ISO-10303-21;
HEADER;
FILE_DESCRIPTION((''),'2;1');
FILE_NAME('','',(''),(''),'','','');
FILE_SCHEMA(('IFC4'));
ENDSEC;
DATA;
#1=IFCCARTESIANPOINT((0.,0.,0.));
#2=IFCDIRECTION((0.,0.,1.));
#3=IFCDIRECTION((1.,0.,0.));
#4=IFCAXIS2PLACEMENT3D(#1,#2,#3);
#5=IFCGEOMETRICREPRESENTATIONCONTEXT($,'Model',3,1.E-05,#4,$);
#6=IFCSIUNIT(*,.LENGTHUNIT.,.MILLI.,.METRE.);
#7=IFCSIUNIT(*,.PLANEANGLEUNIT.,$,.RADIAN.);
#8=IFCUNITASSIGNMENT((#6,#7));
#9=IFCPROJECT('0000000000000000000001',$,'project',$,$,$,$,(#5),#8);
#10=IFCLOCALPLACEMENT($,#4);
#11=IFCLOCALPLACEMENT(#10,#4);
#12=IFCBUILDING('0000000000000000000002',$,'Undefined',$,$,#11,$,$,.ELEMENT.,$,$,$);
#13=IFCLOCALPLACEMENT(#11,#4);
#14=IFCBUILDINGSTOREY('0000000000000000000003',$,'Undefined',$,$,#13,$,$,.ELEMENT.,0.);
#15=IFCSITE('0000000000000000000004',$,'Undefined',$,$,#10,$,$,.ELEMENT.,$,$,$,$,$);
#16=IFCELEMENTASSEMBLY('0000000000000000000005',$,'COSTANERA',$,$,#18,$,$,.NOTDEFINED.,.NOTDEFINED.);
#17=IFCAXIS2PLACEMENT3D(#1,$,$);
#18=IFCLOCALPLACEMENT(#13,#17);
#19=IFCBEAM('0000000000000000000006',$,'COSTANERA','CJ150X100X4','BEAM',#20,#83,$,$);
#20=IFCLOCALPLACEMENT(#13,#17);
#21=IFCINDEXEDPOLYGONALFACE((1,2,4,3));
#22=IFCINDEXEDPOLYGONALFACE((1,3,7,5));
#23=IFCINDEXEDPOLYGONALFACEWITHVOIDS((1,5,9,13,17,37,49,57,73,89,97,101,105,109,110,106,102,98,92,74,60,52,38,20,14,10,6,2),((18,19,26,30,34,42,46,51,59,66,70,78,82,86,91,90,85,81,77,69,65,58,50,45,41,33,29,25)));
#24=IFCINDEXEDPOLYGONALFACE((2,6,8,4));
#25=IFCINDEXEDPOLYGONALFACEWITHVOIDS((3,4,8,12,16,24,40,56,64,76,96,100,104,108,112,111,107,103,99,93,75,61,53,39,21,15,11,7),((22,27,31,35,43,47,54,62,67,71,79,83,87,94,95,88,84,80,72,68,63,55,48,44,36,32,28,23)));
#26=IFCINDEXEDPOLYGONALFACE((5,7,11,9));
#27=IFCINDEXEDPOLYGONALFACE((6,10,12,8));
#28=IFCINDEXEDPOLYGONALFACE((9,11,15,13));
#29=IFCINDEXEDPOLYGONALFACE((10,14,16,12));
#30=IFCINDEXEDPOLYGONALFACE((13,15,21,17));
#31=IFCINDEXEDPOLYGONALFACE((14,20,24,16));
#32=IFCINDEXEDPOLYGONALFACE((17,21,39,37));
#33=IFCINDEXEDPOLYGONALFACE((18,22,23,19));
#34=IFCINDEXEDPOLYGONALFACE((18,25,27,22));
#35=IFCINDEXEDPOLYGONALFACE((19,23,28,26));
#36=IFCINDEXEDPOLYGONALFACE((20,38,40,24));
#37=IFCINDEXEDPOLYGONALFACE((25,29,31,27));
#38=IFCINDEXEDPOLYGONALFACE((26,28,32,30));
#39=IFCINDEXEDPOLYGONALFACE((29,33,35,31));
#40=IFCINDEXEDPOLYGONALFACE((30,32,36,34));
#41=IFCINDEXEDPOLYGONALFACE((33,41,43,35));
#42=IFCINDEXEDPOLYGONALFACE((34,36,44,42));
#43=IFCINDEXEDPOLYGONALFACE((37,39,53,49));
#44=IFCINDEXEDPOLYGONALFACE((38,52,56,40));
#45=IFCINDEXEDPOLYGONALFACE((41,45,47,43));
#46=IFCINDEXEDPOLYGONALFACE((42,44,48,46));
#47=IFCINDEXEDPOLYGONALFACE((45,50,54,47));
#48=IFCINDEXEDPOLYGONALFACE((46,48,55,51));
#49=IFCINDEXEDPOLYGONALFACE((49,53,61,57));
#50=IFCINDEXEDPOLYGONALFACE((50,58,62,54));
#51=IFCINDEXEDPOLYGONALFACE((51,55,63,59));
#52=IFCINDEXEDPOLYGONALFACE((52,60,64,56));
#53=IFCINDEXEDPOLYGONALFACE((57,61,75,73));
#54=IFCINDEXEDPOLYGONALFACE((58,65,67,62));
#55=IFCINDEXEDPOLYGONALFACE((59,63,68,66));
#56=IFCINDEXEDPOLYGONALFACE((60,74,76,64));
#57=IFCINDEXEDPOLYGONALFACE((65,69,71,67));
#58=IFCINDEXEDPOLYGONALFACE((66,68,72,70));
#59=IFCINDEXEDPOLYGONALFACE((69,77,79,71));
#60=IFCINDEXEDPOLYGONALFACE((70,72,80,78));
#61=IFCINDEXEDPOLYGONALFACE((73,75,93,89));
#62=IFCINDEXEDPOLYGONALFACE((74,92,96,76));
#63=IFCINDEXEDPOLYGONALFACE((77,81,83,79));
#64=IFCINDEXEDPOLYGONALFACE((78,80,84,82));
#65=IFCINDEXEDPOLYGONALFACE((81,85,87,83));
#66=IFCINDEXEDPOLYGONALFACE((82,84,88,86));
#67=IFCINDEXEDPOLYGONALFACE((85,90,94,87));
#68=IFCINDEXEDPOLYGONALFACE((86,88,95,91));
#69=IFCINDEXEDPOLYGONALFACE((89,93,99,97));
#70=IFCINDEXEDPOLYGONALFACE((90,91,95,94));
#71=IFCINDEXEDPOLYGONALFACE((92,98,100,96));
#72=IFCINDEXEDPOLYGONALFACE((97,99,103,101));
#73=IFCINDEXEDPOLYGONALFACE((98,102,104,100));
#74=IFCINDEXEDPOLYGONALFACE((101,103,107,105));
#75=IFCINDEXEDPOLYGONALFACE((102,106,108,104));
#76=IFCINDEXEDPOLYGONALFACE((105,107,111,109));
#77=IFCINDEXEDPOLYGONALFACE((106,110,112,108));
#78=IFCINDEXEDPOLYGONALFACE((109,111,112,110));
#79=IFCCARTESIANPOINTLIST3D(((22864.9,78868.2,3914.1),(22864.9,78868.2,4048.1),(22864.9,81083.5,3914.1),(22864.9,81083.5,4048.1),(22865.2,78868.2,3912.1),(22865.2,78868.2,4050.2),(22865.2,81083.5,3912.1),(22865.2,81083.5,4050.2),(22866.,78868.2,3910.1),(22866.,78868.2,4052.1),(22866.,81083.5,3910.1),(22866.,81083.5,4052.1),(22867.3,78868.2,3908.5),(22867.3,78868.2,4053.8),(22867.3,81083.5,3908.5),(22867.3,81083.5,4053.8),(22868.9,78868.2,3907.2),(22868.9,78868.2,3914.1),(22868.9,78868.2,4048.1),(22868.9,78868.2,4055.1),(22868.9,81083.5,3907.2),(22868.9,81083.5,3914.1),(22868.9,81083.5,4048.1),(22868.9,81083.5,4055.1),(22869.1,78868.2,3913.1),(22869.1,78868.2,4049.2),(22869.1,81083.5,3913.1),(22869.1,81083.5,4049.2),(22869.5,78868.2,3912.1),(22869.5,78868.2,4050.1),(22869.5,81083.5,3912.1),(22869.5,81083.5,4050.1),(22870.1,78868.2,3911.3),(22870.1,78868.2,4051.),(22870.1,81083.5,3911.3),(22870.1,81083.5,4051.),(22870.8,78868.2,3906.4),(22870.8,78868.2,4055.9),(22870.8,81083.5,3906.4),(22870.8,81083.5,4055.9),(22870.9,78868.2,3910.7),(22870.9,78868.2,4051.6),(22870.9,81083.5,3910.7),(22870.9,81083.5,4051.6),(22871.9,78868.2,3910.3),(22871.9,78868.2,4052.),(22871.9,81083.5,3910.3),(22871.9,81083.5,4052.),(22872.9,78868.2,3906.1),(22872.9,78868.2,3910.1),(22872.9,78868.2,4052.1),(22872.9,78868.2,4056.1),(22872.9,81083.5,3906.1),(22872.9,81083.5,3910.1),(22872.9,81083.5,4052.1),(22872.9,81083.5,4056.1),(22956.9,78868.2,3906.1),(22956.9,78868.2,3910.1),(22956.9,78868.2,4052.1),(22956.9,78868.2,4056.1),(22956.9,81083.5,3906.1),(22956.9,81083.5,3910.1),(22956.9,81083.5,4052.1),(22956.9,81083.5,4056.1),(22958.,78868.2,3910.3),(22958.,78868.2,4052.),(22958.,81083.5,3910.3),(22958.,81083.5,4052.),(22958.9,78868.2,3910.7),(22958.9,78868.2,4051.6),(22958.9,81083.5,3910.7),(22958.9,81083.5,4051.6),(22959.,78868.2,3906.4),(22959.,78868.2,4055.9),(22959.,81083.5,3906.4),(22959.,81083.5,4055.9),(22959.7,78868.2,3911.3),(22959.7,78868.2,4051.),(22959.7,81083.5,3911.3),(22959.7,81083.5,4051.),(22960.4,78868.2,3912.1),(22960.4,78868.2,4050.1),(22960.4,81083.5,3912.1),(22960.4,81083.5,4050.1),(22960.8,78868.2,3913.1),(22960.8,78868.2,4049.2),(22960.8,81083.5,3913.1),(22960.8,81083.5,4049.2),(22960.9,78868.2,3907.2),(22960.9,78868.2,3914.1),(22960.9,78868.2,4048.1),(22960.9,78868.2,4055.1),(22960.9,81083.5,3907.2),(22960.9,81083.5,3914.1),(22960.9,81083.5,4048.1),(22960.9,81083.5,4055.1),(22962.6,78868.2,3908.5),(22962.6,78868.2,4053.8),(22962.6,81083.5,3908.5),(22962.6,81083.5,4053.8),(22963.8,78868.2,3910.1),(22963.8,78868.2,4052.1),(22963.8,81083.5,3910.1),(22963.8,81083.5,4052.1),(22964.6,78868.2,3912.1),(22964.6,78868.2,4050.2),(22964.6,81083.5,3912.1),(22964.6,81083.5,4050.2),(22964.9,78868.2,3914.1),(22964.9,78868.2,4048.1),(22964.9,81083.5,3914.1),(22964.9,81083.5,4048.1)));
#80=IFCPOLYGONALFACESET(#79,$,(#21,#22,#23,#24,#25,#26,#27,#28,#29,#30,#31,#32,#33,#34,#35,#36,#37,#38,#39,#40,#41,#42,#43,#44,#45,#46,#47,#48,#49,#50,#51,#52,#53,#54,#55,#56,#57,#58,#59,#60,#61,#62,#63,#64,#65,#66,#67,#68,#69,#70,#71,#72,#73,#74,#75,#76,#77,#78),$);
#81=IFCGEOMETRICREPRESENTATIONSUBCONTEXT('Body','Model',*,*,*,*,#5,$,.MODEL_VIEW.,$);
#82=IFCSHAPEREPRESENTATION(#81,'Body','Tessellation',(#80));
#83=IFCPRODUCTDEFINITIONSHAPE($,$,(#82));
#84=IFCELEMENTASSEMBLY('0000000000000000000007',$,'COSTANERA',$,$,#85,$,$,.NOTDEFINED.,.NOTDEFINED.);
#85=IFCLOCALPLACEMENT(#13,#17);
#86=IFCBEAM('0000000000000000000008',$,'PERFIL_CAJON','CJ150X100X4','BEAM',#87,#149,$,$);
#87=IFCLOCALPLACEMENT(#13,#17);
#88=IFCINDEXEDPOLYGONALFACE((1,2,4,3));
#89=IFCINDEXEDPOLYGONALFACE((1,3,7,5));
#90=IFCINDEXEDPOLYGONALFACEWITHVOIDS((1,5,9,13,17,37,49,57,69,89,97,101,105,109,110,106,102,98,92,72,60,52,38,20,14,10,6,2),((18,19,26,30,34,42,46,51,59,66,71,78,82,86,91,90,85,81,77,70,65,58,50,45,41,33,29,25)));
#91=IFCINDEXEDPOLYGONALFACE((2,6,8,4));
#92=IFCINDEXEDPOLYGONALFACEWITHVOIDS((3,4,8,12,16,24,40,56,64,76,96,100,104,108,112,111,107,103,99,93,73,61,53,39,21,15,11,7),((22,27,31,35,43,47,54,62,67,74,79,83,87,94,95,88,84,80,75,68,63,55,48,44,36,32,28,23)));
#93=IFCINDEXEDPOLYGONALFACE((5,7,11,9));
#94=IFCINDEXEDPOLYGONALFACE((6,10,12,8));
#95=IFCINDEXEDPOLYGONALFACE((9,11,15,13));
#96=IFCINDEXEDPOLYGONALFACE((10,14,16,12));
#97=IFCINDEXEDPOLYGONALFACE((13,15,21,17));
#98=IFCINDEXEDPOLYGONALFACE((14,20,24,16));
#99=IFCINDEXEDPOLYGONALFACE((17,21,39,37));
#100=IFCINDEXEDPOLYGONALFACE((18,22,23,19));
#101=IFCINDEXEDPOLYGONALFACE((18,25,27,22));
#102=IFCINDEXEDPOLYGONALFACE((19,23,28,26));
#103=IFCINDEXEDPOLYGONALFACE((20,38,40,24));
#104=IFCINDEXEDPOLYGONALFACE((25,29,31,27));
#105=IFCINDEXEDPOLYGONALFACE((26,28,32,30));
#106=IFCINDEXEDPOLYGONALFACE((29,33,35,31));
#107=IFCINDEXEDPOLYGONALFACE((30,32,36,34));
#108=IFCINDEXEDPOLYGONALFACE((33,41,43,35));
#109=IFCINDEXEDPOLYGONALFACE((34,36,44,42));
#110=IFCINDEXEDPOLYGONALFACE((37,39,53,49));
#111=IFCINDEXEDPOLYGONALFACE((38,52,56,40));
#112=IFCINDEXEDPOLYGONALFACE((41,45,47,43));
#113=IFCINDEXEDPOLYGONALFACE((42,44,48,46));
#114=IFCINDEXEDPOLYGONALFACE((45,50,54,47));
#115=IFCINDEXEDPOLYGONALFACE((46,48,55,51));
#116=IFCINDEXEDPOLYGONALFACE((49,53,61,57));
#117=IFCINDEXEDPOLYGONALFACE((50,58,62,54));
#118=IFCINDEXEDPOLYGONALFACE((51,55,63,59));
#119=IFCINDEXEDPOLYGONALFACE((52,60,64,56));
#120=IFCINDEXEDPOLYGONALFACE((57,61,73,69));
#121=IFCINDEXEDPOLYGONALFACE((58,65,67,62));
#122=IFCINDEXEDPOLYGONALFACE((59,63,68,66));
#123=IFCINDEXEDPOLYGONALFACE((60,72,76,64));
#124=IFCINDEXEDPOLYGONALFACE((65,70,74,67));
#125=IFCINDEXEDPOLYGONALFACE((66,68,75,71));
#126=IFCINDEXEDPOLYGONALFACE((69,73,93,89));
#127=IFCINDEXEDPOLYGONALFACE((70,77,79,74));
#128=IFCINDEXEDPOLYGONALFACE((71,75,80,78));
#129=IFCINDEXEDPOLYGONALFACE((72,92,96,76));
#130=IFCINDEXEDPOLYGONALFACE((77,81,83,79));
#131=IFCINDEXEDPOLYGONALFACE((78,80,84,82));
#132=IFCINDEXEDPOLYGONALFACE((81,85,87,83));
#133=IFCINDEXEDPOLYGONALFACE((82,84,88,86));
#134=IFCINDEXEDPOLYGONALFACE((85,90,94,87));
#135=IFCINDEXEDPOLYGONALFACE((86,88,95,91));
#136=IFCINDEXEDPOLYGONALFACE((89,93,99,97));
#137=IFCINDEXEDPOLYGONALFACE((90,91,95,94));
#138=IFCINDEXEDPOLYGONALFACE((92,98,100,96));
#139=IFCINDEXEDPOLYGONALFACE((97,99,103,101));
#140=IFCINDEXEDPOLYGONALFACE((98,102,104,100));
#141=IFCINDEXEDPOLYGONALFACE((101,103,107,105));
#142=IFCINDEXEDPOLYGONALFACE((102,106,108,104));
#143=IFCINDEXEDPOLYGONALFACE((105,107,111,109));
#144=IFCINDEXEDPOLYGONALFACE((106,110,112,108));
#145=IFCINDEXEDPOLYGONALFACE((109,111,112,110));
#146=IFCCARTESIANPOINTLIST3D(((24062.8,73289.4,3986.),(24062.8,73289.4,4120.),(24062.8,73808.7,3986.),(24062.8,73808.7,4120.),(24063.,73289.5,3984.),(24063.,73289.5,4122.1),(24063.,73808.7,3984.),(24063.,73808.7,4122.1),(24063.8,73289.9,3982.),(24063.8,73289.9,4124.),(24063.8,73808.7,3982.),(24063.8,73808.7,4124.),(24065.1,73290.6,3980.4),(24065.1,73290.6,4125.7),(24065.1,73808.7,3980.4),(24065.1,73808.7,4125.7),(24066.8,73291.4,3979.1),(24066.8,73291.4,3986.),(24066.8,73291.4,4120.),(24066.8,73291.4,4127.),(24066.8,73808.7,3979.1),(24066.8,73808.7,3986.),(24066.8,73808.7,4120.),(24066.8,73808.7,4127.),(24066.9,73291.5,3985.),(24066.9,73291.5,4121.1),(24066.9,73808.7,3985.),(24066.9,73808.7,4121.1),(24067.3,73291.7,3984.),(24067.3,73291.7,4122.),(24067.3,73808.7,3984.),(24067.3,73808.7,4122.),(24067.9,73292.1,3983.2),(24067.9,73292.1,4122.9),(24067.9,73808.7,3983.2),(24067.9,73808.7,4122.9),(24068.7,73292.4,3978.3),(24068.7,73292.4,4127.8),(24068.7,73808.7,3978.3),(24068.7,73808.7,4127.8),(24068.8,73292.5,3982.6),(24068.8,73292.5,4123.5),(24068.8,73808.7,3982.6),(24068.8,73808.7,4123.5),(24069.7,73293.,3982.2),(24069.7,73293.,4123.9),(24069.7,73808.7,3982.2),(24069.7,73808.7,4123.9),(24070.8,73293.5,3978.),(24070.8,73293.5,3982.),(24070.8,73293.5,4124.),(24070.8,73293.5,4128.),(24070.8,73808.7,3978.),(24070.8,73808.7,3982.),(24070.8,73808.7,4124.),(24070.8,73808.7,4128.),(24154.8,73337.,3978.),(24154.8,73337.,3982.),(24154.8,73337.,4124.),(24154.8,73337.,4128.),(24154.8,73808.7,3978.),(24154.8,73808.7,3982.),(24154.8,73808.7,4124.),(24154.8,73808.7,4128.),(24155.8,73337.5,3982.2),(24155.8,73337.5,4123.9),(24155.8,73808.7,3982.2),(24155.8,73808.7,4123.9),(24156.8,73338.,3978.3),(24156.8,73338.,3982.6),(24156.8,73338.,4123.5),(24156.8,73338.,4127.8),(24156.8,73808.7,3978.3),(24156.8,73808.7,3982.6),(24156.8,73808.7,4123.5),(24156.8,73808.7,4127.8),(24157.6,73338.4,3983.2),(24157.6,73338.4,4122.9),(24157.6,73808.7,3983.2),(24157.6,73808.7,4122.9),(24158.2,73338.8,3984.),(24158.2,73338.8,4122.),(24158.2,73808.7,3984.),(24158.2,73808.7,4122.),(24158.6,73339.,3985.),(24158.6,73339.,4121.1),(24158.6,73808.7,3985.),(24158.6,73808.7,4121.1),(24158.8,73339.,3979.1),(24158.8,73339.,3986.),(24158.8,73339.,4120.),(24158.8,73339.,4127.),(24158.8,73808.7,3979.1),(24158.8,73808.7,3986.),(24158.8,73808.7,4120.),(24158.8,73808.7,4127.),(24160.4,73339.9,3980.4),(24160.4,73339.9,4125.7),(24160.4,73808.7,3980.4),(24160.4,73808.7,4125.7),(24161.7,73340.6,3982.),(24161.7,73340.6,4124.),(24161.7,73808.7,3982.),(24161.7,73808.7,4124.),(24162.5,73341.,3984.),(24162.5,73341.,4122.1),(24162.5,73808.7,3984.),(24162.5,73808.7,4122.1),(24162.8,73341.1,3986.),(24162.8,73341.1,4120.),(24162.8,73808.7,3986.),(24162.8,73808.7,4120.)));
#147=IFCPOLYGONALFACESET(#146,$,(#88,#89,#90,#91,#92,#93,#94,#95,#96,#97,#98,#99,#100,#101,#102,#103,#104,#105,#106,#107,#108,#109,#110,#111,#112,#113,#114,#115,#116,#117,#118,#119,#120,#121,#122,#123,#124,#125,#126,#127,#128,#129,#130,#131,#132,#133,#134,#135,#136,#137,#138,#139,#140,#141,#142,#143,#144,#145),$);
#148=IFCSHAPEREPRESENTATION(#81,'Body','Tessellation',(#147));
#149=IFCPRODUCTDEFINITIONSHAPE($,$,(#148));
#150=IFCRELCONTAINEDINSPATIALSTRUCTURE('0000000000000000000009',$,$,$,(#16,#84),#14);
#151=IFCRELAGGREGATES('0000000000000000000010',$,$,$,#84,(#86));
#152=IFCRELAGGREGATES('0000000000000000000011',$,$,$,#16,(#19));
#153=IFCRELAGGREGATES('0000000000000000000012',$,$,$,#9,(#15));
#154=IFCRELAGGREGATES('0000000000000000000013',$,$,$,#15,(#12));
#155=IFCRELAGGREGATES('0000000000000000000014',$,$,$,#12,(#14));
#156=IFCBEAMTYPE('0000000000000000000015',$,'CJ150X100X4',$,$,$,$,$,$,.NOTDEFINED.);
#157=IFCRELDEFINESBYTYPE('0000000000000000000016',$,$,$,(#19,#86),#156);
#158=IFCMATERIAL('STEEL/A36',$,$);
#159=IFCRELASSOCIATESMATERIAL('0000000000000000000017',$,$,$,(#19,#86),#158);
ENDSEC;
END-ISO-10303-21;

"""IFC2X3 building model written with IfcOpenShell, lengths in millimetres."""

from ifc_helpers import new_model, si_unit, frame, origin_with_axes, origin_2d_with_axis, place, context, subcontext, project, spatial, hollow_rectangle, extrude, clip, halfspace, material, type_object, element, aggregate, save


model = new_model("IFC2X3")

# Units and contexts
model_context = context("Model", 3, precision=1e-05, world=origin_with_axes())
body_context = subcontext(model_context, "Body", "Model", "MODEL_VIEW")
ifc_project = project(units=[si_unit("LENGTHUNIT", "METRE", prefix="MILLI"), si_unit("PLANEANGLEUNIT", "RADIAN")], contexts=[model_context])

# Site, building, storey
site_placement = place(None, origin_with_axes())
site = spatial("IfcSite", under=ifc_project, at=site_placement, Name="Undefined", CompositionType="ELEMENT")
building_placement = place(site_placement, origin_with_axes())
building = spatial("IfcBuilding", under=site, at=building_placement, Name="Undefined", CompositionType="ELEMENT")
storey_placement = place(building_placement, origin_with_axes())
storey = spatial("IfcBuildingStorey", under=building, at=storey_placement, Name="Undefined", CompositionType="ELEMENT", Elevation=0.0)

# Element assembly, beam
assembly_1_placement = place(storey_placement, origin_with_axes())
assembly_1 = element("IfcElementAssembly", 1, at=assembly_1_placement, inside=storey, Name="COSTANERA", AssemblyPlace="NOTDEFINED", PredefinedType="NOTDEFINED")
ifc_material_1 = material(Name="STEEL/A36")
beam_type_1 = type_object("IfcBeamType", Name="CJ150X100X4", PredefinedType="NOTDEFINED")
beam_1_placement = place(assembly_1_placement, frame((22914.9, 78861.7, 3981.1), z_axis=(0.0, 0.0, 1.0), x_axis=(0.0, 1.0, 0.0)))
beam_1 = element("IfcBeam", 2, at=beam_1_placement, type_object=beam_type_1, material=ifc_material_1, Name="COSTANERA", Description="CJ150X100X4", ObjectType="BEAM", context=body_context, shape_type="Clipping", body=[
    clip(extrude(hollow_rectangle(XDim=100.0, YDim=150.0, WallThickness=4.0, InnerFilletRadius=4.0, OuterFilletRadius=8.0, at=origin_2d_with_axis()), frame((2221.8, 0.0, 0.0), z_axis=(-1.0, 0.0, 0.0), x_axis=(0.0, -1.0, 0.0)), (0.0, 0.0, 1.0), 2221.8), halfspace(frame((6.5, 0.0, -75.0), z_axis=(1.0, 0.0, 0.0), x_axis=(0.0, -1.0, 0.0)), True)),
])

# Element assembly, beam
assembly_2_placement = place(storey_placement, origin_with_axes())
assembly_2 = element("IfcElementAssembly", 3, at=assembly_2_placement, inside=storey, Name="COSTANERA", AssemblyPlace="NOTDEFINED", PredefinedType="NOTDEFINED")
beam_2_placement = place(assembly_2_placement, frame((24112.8, 73315.2, 4053.0), z_axis=(0.0, 0.0, 1.0), x_axis=(0.0, 1.0, 0.0)))
beam_2 = element("IfcBeam", 4, at=beam_2_placement, type_object=beam_type_1, material=ifc_material_1, Name="PERFIL_CAJON", Description="CJ150X100X4", ObjectType="BEAM", context=body_context, shape_type="Clipping", body=[
    clip(clip(extrude(hollow_rectangle(XDim=100.0, YDim=150.0, WallThickness=4.0, InnerFilletRadius=4.0, OuterFilletRadius=8.0, at=origin_2d_with_axis()), frame((519.6, 0.0, 0.0), z_axis=(-1.0, 0.0, 0.0), x_axis=(0.0, -1.0, 0.0)), (0.0, 0.0, 1.0), 545.8), halfspace(frame((493.5, 0.0, -75.0), z_axis=(-1.0, 0.0, 0.0), x_axis=(0.0, 1.0, 0.0)), True)), halfspace(frame((-25.9, 50.0, 0.0), z_axis=(-0.888172, -0.45951, 0.0), x_axis=(0.0, 0.0, 1.0)), False)),
])

aggregate(assembly_2, [beam_2])
aggregate(assembly_1, [beam_1])

save(model, "model.ifc")
